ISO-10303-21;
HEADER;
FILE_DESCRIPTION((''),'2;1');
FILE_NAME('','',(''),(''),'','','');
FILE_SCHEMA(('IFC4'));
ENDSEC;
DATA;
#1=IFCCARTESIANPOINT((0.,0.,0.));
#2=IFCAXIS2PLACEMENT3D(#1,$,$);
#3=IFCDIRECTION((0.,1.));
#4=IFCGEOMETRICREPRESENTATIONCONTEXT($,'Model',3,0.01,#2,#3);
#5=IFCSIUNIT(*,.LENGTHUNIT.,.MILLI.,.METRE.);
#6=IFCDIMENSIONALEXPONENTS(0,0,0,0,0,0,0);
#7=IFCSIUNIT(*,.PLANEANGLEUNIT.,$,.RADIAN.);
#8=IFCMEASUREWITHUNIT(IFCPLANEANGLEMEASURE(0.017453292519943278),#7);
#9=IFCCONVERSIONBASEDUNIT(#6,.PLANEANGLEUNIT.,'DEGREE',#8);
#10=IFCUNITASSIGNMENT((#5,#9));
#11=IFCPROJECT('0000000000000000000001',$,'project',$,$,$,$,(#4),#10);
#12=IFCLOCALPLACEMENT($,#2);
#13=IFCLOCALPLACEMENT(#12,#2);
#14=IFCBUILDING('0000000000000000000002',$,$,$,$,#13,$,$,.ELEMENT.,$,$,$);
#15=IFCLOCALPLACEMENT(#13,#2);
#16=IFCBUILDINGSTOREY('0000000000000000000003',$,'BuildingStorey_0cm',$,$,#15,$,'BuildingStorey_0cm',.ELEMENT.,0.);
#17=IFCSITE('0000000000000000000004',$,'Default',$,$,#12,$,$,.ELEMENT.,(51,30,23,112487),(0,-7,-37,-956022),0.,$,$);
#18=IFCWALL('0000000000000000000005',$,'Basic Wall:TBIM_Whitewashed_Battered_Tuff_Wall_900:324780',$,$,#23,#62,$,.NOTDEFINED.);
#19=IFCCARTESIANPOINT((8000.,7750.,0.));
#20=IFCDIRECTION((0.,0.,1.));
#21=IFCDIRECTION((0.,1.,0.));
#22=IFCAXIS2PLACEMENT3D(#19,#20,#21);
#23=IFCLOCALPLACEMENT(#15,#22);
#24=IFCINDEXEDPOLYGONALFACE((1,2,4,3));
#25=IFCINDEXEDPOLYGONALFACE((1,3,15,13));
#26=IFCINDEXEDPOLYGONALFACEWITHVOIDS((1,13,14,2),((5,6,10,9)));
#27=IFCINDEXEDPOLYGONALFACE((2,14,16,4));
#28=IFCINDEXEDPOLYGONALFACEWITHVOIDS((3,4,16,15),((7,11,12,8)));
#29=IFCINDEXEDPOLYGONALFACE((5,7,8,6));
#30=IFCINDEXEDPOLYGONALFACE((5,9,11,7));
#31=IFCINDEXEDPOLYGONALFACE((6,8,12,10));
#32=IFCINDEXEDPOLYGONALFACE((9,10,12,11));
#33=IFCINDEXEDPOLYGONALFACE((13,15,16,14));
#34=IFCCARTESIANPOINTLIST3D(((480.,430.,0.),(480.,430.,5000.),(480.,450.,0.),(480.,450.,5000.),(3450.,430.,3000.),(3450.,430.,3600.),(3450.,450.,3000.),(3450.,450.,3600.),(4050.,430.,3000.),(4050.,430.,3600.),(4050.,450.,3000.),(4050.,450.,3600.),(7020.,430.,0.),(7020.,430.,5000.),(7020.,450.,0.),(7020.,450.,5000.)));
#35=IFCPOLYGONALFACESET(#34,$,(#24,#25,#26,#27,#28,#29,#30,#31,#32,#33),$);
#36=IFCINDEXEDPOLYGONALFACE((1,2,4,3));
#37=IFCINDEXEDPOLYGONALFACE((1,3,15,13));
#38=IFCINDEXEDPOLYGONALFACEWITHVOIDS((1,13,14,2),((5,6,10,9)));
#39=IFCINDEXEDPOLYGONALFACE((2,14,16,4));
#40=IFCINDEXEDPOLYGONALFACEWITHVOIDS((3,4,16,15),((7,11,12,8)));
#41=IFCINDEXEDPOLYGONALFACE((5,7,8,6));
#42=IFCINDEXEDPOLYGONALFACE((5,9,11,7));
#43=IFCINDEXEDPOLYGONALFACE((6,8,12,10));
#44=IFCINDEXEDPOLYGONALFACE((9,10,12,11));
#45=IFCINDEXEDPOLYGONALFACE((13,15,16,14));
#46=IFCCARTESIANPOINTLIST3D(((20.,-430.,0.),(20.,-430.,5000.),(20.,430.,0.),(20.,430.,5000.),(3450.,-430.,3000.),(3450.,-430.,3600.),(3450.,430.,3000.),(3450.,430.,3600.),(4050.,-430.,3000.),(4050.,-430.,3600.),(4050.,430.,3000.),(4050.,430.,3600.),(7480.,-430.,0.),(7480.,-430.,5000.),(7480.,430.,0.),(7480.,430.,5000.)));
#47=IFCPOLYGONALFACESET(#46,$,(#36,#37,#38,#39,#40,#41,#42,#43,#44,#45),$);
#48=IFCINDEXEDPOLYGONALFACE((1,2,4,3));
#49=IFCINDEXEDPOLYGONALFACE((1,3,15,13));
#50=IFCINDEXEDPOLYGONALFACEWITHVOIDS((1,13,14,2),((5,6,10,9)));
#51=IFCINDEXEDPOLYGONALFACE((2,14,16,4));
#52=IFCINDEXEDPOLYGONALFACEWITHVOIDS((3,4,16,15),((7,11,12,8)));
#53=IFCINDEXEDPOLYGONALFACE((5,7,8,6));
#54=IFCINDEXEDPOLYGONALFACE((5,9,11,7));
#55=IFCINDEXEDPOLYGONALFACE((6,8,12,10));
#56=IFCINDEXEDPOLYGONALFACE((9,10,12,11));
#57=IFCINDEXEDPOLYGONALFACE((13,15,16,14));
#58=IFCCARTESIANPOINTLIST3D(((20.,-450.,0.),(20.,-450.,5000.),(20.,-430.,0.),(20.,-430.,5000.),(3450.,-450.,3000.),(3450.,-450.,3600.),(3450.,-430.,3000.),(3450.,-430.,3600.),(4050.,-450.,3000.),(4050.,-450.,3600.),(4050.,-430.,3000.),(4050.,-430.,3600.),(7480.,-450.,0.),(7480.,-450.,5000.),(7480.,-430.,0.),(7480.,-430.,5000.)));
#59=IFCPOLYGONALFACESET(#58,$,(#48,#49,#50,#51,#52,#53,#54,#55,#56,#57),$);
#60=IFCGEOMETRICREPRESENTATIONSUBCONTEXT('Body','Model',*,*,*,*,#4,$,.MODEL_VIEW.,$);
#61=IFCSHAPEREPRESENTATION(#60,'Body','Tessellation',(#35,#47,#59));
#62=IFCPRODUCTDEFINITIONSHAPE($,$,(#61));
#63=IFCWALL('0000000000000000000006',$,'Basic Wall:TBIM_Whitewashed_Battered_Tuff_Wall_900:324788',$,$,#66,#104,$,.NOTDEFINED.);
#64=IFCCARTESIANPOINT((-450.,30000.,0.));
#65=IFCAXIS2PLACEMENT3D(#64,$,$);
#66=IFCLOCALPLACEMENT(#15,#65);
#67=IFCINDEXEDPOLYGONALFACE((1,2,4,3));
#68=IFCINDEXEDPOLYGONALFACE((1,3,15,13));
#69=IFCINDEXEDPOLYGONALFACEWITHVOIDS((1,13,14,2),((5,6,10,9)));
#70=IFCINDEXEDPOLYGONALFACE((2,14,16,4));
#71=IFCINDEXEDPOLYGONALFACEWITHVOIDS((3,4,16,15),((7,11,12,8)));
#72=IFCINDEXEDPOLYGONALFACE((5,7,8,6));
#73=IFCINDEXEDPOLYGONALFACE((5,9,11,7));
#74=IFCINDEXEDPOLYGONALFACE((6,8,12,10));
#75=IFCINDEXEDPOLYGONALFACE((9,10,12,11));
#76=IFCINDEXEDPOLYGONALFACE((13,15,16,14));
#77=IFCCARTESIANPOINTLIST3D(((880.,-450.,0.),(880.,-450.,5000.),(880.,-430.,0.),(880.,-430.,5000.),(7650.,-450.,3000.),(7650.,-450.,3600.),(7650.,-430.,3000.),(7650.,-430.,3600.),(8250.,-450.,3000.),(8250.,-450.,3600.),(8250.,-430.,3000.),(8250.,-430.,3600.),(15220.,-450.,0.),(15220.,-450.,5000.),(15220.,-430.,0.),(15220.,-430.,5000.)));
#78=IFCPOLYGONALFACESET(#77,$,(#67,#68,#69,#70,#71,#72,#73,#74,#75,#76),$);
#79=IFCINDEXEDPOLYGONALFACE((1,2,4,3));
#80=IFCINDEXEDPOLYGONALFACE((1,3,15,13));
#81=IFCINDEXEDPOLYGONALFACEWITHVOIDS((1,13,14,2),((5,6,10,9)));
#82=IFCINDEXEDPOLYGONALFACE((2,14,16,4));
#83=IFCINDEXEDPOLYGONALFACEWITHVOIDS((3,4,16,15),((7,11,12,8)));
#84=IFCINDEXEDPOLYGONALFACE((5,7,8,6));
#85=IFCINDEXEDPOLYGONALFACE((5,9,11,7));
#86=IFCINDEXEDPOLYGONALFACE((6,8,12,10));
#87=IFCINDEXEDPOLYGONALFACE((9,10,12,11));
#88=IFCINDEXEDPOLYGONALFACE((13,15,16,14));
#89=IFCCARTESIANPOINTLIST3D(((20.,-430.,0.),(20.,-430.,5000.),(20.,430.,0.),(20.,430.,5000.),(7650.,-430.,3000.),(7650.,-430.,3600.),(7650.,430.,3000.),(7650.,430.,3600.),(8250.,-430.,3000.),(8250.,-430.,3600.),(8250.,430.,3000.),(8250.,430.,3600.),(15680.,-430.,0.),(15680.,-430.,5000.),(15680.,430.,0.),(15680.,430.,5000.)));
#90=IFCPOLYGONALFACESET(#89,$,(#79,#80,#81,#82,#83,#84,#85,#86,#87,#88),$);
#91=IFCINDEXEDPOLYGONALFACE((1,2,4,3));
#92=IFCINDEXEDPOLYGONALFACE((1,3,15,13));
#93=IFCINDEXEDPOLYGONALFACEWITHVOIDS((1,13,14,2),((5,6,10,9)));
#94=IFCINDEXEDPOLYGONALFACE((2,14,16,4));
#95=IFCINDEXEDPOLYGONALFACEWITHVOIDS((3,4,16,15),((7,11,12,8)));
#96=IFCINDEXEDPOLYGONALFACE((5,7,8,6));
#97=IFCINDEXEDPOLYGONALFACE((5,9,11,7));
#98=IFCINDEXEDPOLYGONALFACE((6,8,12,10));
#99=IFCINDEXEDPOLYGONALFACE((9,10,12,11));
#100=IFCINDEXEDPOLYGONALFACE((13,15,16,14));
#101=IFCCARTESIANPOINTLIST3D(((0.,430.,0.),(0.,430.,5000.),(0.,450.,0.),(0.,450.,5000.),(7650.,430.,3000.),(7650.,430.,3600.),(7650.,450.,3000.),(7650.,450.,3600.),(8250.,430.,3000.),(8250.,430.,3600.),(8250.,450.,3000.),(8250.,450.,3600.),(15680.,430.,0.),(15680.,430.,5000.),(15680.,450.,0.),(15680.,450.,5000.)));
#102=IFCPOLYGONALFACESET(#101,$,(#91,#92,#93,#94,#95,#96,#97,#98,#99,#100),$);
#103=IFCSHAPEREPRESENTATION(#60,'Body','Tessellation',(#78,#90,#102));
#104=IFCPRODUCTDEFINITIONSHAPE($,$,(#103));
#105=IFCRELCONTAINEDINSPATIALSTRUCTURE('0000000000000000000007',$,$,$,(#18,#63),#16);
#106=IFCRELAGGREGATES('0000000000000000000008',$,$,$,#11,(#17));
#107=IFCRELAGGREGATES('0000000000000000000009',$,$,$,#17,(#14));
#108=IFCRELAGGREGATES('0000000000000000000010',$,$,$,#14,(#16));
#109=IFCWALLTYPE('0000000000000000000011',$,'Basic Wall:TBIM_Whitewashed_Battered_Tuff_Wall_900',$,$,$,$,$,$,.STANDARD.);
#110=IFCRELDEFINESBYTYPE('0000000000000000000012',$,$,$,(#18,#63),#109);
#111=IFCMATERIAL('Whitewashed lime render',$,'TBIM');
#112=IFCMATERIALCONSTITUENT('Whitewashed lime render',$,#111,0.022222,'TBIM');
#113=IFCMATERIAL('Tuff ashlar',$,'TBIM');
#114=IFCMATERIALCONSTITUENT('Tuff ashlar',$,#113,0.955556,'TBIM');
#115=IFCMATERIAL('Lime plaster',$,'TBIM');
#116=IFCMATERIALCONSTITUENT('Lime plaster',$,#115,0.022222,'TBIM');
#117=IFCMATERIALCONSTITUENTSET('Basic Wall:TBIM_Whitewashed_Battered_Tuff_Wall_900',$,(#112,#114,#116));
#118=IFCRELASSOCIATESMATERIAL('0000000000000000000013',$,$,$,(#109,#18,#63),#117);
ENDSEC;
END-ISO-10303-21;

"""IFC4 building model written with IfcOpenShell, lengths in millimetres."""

from ifc_helpers import new_model, entity, si_unit, converted_unit, direction, frame, origin, place, context, subcontext, project, spatial, indexed_curve, outline, extrude, material, constituent, constituent_set, type_object, element, save


model = new_model("IFC4")

# Units and contexts
model_context = context("Model", 3, precision=0.01, world=origin(), true_north=direction((0.0, 1.0)))
body_context = subcontext(model_context, "Body", "Model", "MODEL_VIEW")
ifc_project = project(units=[si_unit("LENGTHUNIT", "METRE", prefix="MILLI"), converted_unit("PLANEANGLEUNIT", "DEGREE", entity("IfcPlaneAngleMeasure", 0.017453292519943278), si_unit("PLANEANGLEUNIT", "RADIAN"), dimensions=[0, 0, 0, 0, 0, 0, 0])], contexts=[model_context])

# Site, building, storey
site_placement = place(None, origin())
site = spatial("IfcSite", under=ifc_project, at=site_placement, Name="Default", CompositionType="ELEMENT", RefLatitude=(51, 30, 23, 112487), RefLongitude=(0, -7, -37, -956022), RefElevation=0.0)
building_placement = place(site_placement, origin())
building = spatial("IfcBuilding", under=site, at=building_placement, CompositionType="ELEMENT")
storey_placement = place(building_placement, origin())
storey = spatial("IfcBuildingStorey", under=building, at=storey_placement, Name="BuildingStorey_0cm", LongName="BuildingStorey_0cm", CompositionType="ELEMENT", Elevation=0.0)

# Wall, opening
ifc_material_1 = material(Name="Whitewashed lime render", Category="TBIM")
ifc_constituent_1 = constituent(ifc_material_1, Name="Whitewashed lime render", Category="TBIM", fraction=0.022222)
ifc_material_2 = material(Name="Tuff ashlar", Category="TBIM")
ifc_constituent_2 = constituent(ifc_material_2, Name="Tuff ashlar", Category="TBIM", fraction=0.955556)
ifc_material_3 = material(Name="Lime plaster", Category="TBIM")
ifc_constituent_3 = constituent(ifc_material_3, Name="Lime plaster", Category="TBIM", fraction=0.022222)
ifc_constituent_set_1 = constituent_set(constituents=[ifc_constituent_1, ifc_constituent_2, ifc_constituent_3], Name="Basic Wall:TBIM_Whitewashed_Battered_Tuff_Wall_900")
wall_type_1 = type_object("IfcWallType", Name="Basic Wall:TBIM_Whitewashed_Battered_Tuff_Wall_900", PredefinedType="STANDARD", material=ifc_constituent_set_1)
wall_1_placement = place(storey_placement, frame((8000.0, 7750.0, 0.0), z_axis=(0.0, 0.0, 1.0), x_axis=(0.0, 1.0, 0.0)))
wall_1 = element("IfcWall", 1, at=wall_1_placement, inside=storey, type_object=wall_type_1, material=ifc_constituent_set_1, Name="Basic Wall:TBIM_Whitewashed_Battered_Tuff_Wall_900:324780", PredefinedType="NOTDEFINED", context=body_context, shape_type="SweptSolid", body=[
    extrude(outline(indexed_curve([(-3270.0, -2500.0), (-3250.0, -2500.0), (3250.0, -2500.0), (3270.0, -2500.0), (3270.0, 2500.0), (3250.0, 2500.0), (-3250.0, 2500.0), (-3270.0, 2500.0), (-3270.0, -2500.0)], self_intersect=False), holes=[indexed_curve([(-300.0, 1100.0), (300.0, 1100.0), (300.0, 500.0), (-300.0, 500.0), (-300.0, 1100.0)], self_intersect=False)]), frame((3750.0, 450.0, 2500.0), z_axis=(0.0, -1.0, 0.0), x_axis=(1.0, 0.0, 0.0)), (0.0, 0.0, 1.0), 20.0),
    extrude(outline(indexed_curve([(-2500.0, -3730.0), (2500.0, -3730.0), (2500.0, 3730.0), (-2500.0, 3730.0), (-2500.0, -3730.0)], self_intersect=False), holes=[indexed_curve([(1100.0, 300.0), (1100.0, -300.0), (500.0, -300.0), (500.0, 300.0), (1100.0, 300.0)], self_intersect=False)]), frame((3750.0, 430.0, 2500.0), z_axis=(0.0, -1.0, 0.0), x_axis=(0.0, 0.0, 1.0)), (0.0, 0.0, 1.0), 860.0),
    extrude(outline(indexed_curve([(-2500.0, -3730.0), (2500.0, -3730.0), (2500.0, 3730.0), (-2500.0, 3730.0), (-2500.0, -3730.0)], self_intersect=False), holes=[indexed_curve([(1100.0, 300.0), (1100.0, -300.0), (500.0, -300.0), (500.0, 300.0), (1100.0, 300.0)], self_intersect=False)]), frame((3750.0, -430.0, 2500.0), z_axis=(0.0, -1.0, 0.0), x_axis=(0.0, 0.0, 1.0)), (0.0, 0.0, 1.0), 20.0),
])
opening_1_placement = place(wall_1_placement, frame((3450.0, -450.0, 3000.0)))
element("IfcOpeningElement", 2, at=opening_1_placement, cuts=wall_1, PredefinedType="OPENING", context=body_context, shape_type="SweptSolid", body=[
    extrude(outline(indexed_curve([(600.0, 0.0), (600.0, 600.0), (0.0, 600.0), (0.0, 0.0), (600.0, 0.0)], self_intersect=False)), frame((0.0, 0.0, 0.0), z_axis=(0.0, 1.0, 0.0), x_axis=(0.0, 0.0, 1.0)), (0.0, 0.0, 1.0), 900.0),
])

# Wall, openings
wall_2_placement = place(storey_placement, frame((-450.0, 30000.0, 0.0)))
wall_2 = element("IfcWall", 3, at=wall_2_placement, inside=storey, type_object=wall_type_1, material=ifc_constituent_set_1, Name="Basic Wall:TBIM_Whitewashed_Battered_Tuff_Wall_900:324788", PredefinedType="NOTDEFINED", context=body_context, shape_type="SweptSolid", body=[
    extrude(outline(indexed_curve([(-7150.0, -6.7), (7150.0, -6.7), (7170.0, -6.7), (7170.0, 13.3), (-7170.0, 13.3), (-7170.0, -6.7), (-7150.0, -6.7)], self_intersect=False)), frame((8050.0, -443.3, 0.0)), (0.0, 0.0, 1.0), 5000.0),
    extrude(outline(indexed_curve([(-2500.0, -7830.0), (2500.0, -7830.0), (2500.0, 7830.0), (-2500.0, 7830.0), (-2500.0, -7830.0)], self_intersect=False), holes=[indexed_curve([(-500.0, 200.0), (-500.0, -400.0), (-1100.0, -400.0), (-1100.0, 200.0), (-500.0, 200.0)], self_intersect=False)]), frame((7850.0, -430.0, 2500.0), z_axis=(0.0, 1.0, 0.0), x_axis=(0.0, 0.0, -1.0)), (0.0, 0.0, 1.0), 860.0),
    extrude(outline(indexed_curve([(-10.0, -7840.0), (10.0, -7840.0), (10.0, 7840.0), (-10.0, 7840.0), (-10.0, -7840.0)], self_intersect=False)), frame((7840.0, 440.0, 0.0), z_axis=(0.0, 0.0, 1.0), x_axis=(0.0, -1.0, 0.0)), (0.0, 0.0, 1.0), 5000.0),
])
opening_2_placement = place(storey_placement, frame((-450.0, 30000.0, 0.0)))
element("IfcOpeningElement", 4, at=opening_2_placement, cuts=wall_2, PredefinedType="OPENING", context=body_context, shape_type="SweptSolid", body=[
    extrude(outline(indexed_curve([(-300.0, -300.0), (300.0, -300.0), (300.0, 300.0), (-300.0, 300.0), (-300.0, -300.0)], self_intersect=False)), frame((7950.0, 450.0, 3300.0), z_axis=(0.0, -1.0, 0.0), x_axis=(0.0, 0.0, -1.0)), (0.0, 0.0, 1.0), 20.0),
])
opening_3_placement = place(storey_placement, frame((-450.0, 30000.0, 0.0)))
element("IfcOpeningElement", 5, at=opening_3_placement, cuts=wall_2, PredefinedType="OPENING", context=body_context, shape_type="SweptSolid", body=[
    extrude(outline(indexed_curve([(-300.0, -300.0), (300.0, -300.0), (300.0, 300.0), (-300.0, 300.0), (-300.0, -300.0)], self_intersect=False)), frame((7950.0, -450.0, 3300.0), z_axis=(0.0, 1.0, 0.0), x_axis=(1.0, 0.0, 0.0)), (0.0, 0.0, 1.0), 20.0),
])
opening_4_placement = place(wall_2_placement, frame((7650.0, -450.0, 3000.0)))
element("IfcOpeningElement", 6, at=opening_4_placement, cuts=wall_2, PredefinedType="OPENING", context=body_context, shape_type="SweptSolid", body=[
    extrude(outline(indexed_curve([(600.0, 0.0), (600.0, 600.0), (0.0, 600.0), (0.0, 0.0), (600.0, 0.0)], self_intersect=False)), frame((0.0, 0.0, 0.0), z_axis=(0.0, 1.0, 0.0), x_axis=(0.0, 0.0, 1.0)), (0.0, 0.0, 1.0), 900.0),
])

save(model, "model.ifc")
